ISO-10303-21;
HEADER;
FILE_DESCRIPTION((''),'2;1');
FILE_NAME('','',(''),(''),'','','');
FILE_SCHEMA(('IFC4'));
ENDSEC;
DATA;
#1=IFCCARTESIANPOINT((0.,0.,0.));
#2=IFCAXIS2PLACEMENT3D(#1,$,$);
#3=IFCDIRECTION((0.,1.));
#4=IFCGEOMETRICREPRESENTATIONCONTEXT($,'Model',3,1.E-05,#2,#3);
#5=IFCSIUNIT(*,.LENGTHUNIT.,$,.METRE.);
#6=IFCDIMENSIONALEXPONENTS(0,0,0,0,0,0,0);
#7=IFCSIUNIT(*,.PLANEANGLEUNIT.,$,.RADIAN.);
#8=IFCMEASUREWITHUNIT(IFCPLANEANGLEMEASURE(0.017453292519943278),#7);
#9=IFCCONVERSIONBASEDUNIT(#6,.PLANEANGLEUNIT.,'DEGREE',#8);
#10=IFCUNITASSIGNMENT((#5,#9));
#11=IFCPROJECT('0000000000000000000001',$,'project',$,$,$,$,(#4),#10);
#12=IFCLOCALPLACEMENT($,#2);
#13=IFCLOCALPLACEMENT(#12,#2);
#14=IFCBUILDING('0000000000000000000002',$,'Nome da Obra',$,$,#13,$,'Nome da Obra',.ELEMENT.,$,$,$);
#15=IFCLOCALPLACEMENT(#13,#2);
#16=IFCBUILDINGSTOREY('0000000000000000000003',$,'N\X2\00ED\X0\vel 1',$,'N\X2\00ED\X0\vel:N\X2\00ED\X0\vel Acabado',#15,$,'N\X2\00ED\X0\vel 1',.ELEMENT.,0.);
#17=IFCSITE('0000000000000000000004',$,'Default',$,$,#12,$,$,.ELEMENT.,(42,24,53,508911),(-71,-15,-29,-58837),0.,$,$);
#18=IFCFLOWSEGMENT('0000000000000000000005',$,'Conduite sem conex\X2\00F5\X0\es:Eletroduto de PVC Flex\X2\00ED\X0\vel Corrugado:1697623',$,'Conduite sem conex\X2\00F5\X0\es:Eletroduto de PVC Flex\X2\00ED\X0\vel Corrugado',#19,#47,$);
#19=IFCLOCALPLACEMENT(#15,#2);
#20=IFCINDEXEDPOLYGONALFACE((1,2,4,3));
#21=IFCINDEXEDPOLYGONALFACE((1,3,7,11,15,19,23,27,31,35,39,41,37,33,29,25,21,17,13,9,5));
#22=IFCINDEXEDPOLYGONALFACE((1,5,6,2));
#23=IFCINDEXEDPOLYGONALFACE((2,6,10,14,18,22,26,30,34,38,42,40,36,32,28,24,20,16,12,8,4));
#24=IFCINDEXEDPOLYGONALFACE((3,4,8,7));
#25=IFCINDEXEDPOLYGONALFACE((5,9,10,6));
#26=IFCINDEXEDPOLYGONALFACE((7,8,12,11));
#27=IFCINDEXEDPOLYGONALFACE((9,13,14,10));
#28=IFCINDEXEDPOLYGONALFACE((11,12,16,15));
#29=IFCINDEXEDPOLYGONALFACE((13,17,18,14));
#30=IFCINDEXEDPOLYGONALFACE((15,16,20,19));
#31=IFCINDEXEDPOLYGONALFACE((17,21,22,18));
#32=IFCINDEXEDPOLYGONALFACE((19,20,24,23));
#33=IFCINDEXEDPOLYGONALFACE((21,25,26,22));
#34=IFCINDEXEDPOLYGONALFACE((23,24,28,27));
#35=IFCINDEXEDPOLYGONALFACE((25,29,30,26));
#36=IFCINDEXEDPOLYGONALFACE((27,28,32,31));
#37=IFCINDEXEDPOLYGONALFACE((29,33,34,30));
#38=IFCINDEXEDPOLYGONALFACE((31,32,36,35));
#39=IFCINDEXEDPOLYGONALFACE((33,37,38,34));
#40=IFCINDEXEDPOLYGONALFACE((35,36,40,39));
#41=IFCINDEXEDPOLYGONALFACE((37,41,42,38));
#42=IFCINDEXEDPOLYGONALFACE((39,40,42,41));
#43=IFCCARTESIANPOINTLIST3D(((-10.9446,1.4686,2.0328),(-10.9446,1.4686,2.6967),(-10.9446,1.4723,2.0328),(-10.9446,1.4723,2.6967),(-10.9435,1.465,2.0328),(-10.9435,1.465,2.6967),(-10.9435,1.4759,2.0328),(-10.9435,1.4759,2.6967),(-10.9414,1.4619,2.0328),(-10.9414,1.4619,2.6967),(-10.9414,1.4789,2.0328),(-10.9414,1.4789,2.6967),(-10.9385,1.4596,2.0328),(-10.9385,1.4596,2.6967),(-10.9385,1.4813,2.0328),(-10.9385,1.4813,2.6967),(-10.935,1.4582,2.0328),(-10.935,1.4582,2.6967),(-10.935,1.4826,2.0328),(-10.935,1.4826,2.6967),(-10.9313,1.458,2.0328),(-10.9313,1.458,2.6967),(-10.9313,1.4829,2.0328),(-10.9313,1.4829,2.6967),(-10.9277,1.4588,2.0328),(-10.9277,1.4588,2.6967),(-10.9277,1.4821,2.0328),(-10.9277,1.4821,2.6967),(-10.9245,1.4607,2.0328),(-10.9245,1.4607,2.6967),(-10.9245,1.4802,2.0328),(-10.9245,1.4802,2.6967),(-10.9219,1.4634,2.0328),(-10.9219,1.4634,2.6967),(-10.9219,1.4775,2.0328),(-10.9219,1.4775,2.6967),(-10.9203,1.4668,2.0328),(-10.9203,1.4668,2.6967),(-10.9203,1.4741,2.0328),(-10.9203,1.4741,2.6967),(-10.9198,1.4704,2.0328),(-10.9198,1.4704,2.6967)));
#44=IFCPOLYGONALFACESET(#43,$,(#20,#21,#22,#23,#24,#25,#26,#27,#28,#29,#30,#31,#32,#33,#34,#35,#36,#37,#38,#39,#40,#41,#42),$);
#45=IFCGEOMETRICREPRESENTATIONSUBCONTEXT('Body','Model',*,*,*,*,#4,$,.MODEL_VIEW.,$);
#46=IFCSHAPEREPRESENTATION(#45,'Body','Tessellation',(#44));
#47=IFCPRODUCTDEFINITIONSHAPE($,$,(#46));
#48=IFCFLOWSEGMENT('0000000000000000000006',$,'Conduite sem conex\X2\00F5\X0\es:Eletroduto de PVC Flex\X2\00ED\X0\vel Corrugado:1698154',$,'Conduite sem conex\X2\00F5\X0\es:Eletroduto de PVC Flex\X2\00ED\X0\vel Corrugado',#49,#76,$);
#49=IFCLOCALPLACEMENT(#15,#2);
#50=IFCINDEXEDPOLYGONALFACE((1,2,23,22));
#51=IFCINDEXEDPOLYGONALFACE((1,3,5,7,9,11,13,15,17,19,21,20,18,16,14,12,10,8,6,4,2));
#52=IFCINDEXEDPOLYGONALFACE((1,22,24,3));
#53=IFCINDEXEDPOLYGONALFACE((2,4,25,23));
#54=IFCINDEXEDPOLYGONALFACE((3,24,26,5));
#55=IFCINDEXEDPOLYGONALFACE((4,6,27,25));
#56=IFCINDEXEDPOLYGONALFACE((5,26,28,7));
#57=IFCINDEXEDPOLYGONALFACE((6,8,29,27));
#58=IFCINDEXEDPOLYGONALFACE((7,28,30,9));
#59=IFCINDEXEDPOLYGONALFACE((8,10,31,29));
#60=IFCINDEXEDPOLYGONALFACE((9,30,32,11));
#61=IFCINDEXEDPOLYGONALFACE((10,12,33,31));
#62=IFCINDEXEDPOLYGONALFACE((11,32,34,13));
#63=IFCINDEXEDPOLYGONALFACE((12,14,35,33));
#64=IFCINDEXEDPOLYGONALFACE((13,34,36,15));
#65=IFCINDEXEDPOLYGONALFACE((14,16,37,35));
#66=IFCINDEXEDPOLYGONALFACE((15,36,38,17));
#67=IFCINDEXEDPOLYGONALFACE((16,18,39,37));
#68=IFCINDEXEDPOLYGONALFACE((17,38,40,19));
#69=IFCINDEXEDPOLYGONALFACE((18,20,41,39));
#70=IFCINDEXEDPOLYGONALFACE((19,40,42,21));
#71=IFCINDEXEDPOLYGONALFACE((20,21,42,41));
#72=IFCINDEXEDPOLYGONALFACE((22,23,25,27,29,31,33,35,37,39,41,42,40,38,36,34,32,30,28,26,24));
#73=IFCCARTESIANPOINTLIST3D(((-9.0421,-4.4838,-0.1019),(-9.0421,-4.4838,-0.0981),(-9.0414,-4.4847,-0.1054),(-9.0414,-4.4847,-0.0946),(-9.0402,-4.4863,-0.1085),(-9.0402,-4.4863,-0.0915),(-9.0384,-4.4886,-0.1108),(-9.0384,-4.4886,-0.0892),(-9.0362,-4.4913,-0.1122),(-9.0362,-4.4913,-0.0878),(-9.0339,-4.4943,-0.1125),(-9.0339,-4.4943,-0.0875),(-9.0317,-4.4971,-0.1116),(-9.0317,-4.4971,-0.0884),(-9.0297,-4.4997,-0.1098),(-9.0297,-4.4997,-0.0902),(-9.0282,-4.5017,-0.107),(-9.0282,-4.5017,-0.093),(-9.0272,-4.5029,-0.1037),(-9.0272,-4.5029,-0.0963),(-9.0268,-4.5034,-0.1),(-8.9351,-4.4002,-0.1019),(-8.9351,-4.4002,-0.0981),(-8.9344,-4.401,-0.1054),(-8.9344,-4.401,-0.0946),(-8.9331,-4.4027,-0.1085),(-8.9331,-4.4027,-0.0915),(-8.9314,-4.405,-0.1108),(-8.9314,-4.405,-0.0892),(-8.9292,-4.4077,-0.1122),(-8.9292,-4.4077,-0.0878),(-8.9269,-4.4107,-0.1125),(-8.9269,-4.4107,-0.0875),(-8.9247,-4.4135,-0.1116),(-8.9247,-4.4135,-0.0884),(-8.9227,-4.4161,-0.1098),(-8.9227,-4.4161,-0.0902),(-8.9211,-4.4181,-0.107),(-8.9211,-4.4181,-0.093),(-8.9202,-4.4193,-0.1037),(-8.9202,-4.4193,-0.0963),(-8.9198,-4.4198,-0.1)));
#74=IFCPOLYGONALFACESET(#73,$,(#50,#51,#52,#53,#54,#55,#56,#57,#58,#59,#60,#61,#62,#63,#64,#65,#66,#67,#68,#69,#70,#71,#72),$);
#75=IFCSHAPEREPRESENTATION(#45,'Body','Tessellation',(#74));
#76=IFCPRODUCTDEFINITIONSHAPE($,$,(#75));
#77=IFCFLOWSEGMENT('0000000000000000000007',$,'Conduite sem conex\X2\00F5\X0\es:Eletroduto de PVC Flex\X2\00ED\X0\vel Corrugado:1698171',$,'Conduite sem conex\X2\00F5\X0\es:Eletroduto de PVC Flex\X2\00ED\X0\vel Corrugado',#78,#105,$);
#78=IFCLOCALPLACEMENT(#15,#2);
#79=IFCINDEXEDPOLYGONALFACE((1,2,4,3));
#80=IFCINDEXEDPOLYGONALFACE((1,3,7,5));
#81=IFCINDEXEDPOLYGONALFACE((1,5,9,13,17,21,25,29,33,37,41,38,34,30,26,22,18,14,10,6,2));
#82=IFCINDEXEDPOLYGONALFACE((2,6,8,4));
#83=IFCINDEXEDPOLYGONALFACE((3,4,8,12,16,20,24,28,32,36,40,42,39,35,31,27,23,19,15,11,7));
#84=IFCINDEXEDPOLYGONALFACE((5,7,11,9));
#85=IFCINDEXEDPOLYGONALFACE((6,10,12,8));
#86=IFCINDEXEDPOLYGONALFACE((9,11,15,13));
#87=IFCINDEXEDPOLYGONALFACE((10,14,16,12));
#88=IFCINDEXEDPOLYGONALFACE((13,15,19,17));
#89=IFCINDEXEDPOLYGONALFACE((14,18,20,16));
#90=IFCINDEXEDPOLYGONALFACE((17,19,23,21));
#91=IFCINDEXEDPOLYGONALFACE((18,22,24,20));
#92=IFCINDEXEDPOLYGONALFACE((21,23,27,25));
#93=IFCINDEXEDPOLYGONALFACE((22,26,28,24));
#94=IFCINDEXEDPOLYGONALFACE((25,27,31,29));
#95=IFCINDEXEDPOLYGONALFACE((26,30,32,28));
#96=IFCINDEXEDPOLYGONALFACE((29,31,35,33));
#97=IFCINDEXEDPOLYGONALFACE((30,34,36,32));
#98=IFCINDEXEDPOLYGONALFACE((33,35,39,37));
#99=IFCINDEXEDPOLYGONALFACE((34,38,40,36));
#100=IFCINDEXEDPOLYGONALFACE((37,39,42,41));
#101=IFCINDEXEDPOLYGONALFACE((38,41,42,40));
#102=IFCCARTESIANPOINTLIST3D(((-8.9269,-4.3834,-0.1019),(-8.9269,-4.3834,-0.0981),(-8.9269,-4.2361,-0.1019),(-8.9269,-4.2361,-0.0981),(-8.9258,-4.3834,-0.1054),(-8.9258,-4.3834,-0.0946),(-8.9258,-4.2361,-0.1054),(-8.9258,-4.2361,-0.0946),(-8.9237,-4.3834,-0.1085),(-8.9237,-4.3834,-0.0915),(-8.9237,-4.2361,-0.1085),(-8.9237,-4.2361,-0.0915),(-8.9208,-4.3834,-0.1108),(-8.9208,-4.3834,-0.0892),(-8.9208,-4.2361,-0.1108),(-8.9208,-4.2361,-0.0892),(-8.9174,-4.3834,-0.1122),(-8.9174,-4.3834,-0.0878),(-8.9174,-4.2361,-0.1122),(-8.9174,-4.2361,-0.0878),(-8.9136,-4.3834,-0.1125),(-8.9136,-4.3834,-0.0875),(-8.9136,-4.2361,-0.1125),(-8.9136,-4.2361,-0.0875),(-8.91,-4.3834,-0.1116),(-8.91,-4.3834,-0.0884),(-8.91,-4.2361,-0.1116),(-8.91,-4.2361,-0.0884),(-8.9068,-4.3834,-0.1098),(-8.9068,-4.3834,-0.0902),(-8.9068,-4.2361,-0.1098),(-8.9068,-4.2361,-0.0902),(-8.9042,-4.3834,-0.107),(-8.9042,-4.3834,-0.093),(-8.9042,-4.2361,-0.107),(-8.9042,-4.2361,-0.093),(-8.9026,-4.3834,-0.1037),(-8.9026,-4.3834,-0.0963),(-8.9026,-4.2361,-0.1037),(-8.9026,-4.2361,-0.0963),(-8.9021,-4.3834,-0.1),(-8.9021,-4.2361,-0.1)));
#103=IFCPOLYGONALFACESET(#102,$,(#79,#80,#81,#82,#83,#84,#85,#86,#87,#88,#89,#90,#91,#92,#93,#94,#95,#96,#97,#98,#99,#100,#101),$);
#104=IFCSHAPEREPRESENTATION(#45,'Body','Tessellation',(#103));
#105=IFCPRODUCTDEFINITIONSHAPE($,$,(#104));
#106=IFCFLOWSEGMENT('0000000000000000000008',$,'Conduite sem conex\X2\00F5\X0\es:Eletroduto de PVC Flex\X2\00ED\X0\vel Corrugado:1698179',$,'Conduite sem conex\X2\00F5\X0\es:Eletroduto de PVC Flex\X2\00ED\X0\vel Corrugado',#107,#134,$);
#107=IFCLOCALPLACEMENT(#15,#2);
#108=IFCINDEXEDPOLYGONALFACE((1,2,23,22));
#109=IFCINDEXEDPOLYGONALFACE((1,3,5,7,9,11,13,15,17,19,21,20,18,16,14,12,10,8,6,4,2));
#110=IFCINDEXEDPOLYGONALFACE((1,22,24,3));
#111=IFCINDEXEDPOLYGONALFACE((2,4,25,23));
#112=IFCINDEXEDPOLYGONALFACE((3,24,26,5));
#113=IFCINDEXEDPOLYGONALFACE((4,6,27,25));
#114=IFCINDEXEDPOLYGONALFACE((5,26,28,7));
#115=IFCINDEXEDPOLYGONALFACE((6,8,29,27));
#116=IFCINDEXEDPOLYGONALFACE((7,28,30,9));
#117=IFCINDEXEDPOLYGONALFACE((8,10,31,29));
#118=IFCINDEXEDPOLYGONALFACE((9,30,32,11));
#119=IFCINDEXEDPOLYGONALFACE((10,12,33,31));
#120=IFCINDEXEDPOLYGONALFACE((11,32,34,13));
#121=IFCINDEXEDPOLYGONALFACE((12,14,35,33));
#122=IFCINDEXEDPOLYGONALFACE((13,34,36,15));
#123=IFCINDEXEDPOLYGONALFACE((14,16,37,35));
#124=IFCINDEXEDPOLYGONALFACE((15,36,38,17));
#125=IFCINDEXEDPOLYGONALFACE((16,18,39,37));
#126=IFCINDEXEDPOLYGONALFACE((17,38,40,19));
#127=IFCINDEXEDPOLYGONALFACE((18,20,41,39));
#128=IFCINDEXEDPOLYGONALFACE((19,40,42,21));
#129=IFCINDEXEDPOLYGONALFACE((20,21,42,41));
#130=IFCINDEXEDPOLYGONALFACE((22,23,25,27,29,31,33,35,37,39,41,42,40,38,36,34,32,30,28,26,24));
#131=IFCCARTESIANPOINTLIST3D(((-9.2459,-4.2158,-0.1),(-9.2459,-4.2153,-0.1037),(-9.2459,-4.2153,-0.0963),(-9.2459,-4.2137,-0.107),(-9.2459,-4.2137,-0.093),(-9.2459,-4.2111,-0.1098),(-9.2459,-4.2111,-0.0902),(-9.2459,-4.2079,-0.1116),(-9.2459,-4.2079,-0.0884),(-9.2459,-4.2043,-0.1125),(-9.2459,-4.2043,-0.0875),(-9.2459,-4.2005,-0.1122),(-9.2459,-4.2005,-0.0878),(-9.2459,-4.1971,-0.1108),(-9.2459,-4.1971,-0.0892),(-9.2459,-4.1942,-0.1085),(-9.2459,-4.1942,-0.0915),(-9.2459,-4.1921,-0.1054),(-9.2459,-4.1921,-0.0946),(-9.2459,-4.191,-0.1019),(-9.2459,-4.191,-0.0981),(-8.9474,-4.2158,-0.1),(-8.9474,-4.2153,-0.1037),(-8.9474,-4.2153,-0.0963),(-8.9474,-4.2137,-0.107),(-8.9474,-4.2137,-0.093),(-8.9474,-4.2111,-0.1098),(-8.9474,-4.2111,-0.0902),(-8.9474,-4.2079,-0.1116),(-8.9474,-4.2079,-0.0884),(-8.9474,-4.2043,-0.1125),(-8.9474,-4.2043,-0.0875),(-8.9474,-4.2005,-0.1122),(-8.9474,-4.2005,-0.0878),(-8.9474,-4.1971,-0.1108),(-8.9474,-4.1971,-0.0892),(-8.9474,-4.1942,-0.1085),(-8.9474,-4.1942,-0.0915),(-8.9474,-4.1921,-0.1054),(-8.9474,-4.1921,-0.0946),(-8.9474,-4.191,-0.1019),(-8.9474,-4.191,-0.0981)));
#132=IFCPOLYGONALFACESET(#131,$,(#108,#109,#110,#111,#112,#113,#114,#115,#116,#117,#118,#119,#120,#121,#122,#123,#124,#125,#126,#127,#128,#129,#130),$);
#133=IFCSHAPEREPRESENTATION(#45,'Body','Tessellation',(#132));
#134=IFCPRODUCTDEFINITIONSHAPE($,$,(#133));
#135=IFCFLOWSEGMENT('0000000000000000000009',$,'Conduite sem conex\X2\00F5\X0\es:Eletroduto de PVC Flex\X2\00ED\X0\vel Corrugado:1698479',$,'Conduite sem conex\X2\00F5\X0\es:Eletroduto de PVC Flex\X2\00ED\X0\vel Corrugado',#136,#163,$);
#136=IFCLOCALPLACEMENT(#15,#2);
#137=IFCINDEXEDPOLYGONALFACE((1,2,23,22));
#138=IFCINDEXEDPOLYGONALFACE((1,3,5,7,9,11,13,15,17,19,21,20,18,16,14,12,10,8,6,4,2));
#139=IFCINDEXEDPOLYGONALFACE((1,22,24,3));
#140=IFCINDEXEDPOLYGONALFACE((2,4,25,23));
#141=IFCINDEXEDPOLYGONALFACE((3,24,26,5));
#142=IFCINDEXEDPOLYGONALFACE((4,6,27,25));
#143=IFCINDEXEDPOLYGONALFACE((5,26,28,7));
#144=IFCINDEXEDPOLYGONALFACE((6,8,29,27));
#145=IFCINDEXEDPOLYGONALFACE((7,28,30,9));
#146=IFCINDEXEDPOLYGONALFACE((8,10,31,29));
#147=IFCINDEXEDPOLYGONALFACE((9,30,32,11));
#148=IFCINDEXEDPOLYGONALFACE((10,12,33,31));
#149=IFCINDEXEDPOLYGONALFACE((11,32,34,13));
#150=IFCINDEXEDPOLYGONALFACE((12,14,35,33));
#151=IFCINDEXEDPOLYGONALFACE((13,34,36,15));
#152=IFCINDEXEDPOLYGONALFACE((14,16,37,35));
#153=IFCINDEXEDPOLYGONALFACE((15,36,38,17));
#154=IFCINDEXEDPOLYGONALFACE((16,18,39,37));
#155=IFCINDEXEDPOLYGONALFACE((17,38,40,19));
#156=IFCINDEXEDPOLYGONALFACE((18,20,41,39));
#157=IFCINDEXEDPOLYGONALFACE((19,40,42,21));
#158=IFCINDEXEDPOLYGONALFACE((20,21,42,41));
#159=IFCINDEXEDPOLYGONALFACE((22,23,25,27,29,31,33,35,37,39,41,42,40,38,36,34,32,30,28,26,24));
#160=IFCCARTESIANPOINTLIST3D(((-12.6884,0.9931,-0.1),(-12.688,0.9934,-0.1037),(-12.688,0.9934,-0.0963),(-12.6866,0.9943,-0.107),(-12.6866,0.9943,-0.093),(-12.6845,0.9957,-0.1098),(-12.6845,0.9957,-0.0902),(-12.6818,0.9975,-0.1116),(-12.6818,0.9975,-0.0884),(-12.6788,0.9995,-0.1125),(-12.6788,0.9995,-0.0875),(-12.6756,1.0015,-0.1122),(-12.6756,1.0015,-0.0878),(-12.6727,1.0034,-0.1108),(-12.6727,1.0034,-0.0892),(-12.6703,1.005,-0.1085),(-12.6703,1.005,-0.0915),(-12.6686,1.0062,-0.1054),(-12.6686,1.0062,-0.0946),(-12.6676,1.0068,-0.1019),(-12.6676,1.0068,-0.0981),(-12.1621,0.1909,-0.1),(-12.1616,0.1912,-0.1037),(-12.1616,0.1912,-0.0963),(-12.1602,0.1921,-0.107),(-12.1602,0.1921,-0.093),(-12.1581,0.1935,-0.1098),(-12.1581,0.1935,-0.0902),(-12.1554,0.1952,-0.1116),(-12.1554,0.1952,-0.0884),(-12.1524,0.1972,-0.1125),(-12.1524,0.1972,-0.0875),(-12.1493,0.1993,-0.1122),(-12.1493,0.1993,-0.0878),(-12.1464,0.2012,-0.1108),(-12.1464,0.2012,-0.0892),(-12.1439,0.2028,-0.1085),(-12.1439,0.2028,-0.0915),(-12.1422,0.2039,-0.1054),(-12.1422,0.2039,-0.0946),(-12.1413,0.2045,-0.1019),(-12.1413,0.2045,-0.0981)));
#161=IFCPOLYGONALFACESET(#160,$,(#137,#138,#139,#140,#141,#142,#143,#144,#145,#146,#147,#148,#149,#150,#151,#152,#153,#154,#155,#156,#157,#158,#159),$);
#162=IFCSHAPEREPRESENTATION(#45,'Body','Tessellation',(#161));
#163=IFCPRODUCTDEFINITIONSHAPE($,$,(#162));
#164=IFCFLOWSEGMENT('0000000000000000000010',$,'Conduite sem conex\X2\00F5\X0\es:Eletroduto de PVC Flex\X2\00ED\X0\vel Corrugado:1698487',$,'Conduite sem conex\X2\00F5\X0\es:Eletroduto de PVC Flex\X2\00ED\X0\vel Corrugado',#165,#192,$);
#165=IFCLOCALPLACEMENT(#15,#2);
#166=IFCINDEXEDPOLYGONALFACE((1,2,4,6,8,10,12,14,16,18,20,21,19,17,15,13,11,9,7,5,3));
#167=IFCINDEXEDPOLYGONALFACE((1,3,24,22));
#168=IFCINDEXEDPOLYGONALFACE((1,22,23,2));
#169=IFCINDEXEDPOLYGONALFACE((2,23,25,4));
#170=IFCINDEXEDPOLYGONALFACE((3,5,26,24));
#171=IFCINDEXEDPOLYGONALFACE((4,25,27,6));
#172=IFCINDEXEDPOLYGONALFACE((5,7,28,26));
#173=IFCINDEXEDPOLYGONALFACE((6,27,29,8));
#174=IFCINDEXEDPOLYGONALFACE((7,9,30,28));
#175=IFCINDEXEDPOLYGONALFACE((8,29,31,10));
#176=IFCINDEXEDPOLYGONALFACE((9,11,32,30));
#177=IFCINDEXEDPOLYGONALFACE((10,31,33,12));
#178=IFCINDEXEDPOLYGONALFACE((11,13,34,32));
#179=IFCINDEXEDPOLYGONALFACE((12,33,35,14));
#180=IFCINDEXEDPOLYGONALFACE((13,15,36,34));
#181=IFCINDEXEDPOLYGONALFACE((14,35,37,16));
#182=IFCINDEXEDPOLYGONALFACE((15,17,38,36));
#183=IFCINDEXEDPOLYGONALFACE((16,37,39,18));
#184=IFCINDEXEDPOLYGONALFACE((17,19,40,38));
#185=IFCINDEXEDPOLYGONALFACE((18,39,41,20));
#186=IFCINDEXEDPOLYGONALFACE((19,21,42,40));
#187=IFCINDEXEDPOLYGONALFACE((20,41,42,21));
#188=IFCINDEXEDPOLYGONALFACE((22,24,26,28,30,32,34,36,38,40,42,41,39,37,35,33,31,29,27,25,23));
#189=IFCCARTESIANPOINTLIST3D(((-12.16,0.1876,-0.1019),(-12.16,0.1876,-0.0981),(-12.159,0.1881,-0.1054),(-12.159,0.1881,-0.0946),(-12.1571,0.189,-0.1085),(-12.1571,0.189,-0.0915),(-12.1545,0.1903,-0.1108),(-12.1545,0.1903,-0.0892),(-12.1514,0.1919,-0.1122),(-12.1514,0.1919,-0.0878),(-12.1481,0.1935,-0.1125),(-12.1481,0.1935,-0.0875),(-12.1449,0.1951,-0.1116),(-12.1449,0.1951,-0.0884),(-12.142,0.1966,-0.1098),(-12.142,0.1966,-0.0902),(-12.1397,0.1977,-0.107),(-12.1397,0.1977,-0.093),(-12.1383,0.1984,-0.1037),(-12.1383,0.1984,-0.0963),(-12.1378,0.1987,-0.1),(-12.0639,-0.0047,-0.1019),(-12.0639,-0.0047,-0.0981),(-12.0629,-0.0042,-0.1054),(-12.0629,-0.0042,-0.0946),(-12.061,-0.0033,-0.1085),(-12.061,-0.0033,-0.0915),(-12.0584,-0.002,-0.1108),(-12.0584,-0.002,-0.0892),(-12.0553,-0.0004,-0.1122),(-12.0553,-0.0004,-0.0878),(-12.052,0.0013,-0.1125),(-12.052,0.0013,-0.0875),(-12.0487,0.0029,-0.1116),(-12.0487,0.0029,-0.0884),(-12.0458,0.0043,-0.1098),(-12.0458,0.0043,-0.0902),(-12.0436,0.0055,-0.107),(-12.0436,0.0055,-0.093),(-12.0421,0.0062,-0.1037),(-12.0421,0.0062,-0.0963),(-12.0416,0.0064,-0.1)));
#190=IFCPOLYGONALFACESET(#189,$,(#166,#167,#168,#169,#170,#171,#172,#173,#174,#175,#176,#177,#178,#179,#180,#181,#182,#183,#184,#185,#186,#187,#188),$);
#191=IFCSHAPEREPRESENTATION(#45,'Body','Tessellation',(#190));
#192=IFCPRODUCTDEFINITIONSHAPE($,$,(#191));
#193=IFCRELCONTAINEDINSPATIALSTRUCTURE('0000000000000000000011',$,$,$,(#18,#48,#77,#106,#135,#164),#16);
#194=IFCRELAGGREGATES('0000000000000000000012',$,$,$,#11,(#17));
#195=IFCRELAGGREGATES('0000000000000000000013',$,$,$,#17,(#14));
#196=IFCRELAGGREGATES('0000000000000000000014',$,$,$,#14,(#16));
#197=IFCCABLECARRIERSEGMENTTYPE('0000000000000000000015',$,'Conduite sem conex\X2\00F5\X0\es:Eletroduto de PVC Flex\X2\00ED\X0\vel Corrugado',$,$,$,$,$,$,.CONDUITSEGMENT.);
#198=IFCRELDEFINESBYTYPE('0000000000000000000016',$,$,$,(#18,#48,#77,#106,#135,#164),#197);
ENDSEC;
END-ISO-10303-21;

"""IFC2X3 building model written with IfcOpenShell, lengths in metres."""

from ifc_helpers import new_model, entity, si_unit, converted_unit, direction, frame, frame_2d, origin, origin_2d_with_axis, place, context, subcontext, project, spatial, circle, extrude, type_object, element, save


model = new_model("IFC2X3")

# Units and contexts
model_context = context("Model", 3, precision=1e-05, world=origin(), true_north=direction((0.0, 1.0)))
body_context = subcontext(model_context, "Body", "Model", "MODEL_VIEW")
ifc_project = project(units=[si_unit("LENGTHUNIT", "METRE"), converted_unit("PLANEANGLEUNIT", "DEGREE", entity("IfcPlaneAngleMeasure", 0.017453292519943278), si_unit("PLANEANGLEUNIT", "RADIAN"), dimensions=[0, 0, 0, 0, 0, 0, 0])], contexts=[model_context])

# Site, building, storey
site_placement = place(None, origin())
site = spatial("IfcSite", under=ifc_project, at=site_placement, Name="Default", CompositionType="ELEMENT", RefLatitude=(42, 24, 53, 508911), RefLongitude=(-71, -15, -29, -58837), RefElevation=0.0)
building_placement = place(site_placement, origin())
building = spatial("IfcBuilding", under=site, at=building_placement, Name="Nome da Obra", LongName="Nome da Obra", CompositionType="ELEMENT")
storey_placement = place(building_placement, origin())
storey = spatial("IfcBuildingStorey", under=building, at=storey_placement, Name="Nível 1", ObjectType="Nível:Nível Acabado", LongName="Nível 1", CompositionType="ELEMENT", Elevation=0.0)

# Flow segments
cable_carrier_segment_type = type_object("IfcCableCarrierSegmentType", Name="Conduite sem conexões:Eletroduto de PVC Flexível Corrugado", PredefinedType="CONDUITSEGMENT")
flow_segment_1_placement = place(storey_placement, origin())
element("IfcFlowSegment", 1, at=flow_segment_1_placement, inside=storey, type_object=cable_carrier_segment_type, Name="Conduite sem conexões:Eletroduto de PVC Flexível Corrugado:1697623", ObjectType="Conduite sem conexões:Eletroduto de PVC Flexível Corrugado", context=body_context, shape_type="SweptSolid", body=[
    extrude(circle(Radius=0.0125, at=origin_2d_with_axis()), frame((-10.9323, 1.4704, 2.0328)), (0.0, 0.0, 1.0), 0.6639),
])
flow_segment_2_placement = place(storey_placement, origin())
element("IfcFlowSegment", 2, at=flow_segment_2_placement, inside=storey, type_object=cable_carrier_segment_type, Name="Conduite sem conexões:Eletroduto de PVC Flexível Corrugado:1698154", ObjectType="Conduite sem conexões:Eletroduto de PVC Flexível Corrugado", context=body_context, shape_type="SweptSolid", body=[
    extrude(circle(Radius=0.0125, at=frame_2d((0.0, 0.0), x_axis=(1.0, 0.0))), frame((-9.0345, -4.4935, -0.1), z_axis=(0.788011, 0.615661, 0.0), x_axis=(0.615661, -0.788011, 0.0)), (0.0, 0.0, 1.0), 0.1358),
])
flow_segment_3_placement = place(storey_placement, origin())
element("IfcFlowSegment", 3, at=flow_segment_3_placement, inside=storey, type_object=cable_carrier_segment_type, Name="Conduite sem conexões:Eletroduto de PVC Flexível Corrugado:1698171", ObjectType="Conduite sem conexões:Eletroduto de PVC Flexível Corrugado", context=body_context, shape_type="SweptSolid", body=[
    extrude(circle(Radius=0.0125, at=frame_2d((0.0, 0.0), x_axis=(1.0, 0.0))), frame((-8.9146, -4.3834, -0.1), z_axis=(0.0, 1.0, 0.0), x_axis=(1.0, 0.0, 0.0)), (0.0, 0.0, 1.0), 0.1473),
])
flow_segment_4_placement = place(storey_placement, origin())
element("IfcFlowSegment", 4, at=flow_segment_4_placement, inside=storey, type_object=cable_carrier_segment_type, Name="Conduite sem conexões:Eletroduto de PVC Flexível Corrugado:1698179", ObjectType="Conduite sem conexões:Eletroduto de PVC Flexível Corrugado", context=body_context, shape_type="SweptSolid", body=[
    extrude(circle(Radius=0.0125, at=frame_2d((0.0, 0.0), x_axis=(1.0, 0.0))), frame((-9.2459, -4.2033, -0.1), z_axis=(1.0, 0.0, 0.0), x_axis=(0.0, -1.0, 0.0)), (0.0, 0.0, 1.0), 0.2986),
])
flow_segment_5_placement = place(storey_placement, origin())
element("IfcFlowSegment", 5, at=flow_segment_5_placement, inside=storey, type_object=cable_carrier_segment_type, Name="Conduite sem conexões:Eletroduto de PVC Flexível Corrugado:1698479", ObjectType="Conduite sem conexões:Eletroduto de PVC Flexível Corrugado", context=body_context, shape_type="SweptSolid", body=[
    extrude(circle(Radius=0.0125, at=frame_2d((0.0, 0.0), x_axis=(1.0, 0.0))), frame((-12.1516, 0.1977, -0.1), z_axis=(-0.548576, 0.836101, 0.0), x_axis=(-0.836101, -0.548576, 0.0)), (0.0, 0.0, 1.0), 0.9595),
])
flow_segment_6_placement = place(storey_placement, origin())
element("IfcFlowSegment", 6, at=flow_segment_6_placement, inside=storey, type_object=cable_carrier_segment_type, Name="Conduite sem conexões:Eletroduto de PVC Flexível Corrugado:1698487", ObjectType="Conduite sem conexões:Eletroduto de PVC Flexível Corrugado", context=body_context, shape_type="SweptSolid", body=[
    extrude(circle(Radius=0.0125, at=frame_2d((0.0, 0.0), x_axis=(1.0, 0.0))), frame((-12.1489, 0.1931, -0.1), z_axis=(0.447189, -0.89444, 0.0), x_axis=(0.89444, 0.447189, 0.0)), (0.0, 0.0, 1.0), 0.215),
])

save(model, "model.ifc")
